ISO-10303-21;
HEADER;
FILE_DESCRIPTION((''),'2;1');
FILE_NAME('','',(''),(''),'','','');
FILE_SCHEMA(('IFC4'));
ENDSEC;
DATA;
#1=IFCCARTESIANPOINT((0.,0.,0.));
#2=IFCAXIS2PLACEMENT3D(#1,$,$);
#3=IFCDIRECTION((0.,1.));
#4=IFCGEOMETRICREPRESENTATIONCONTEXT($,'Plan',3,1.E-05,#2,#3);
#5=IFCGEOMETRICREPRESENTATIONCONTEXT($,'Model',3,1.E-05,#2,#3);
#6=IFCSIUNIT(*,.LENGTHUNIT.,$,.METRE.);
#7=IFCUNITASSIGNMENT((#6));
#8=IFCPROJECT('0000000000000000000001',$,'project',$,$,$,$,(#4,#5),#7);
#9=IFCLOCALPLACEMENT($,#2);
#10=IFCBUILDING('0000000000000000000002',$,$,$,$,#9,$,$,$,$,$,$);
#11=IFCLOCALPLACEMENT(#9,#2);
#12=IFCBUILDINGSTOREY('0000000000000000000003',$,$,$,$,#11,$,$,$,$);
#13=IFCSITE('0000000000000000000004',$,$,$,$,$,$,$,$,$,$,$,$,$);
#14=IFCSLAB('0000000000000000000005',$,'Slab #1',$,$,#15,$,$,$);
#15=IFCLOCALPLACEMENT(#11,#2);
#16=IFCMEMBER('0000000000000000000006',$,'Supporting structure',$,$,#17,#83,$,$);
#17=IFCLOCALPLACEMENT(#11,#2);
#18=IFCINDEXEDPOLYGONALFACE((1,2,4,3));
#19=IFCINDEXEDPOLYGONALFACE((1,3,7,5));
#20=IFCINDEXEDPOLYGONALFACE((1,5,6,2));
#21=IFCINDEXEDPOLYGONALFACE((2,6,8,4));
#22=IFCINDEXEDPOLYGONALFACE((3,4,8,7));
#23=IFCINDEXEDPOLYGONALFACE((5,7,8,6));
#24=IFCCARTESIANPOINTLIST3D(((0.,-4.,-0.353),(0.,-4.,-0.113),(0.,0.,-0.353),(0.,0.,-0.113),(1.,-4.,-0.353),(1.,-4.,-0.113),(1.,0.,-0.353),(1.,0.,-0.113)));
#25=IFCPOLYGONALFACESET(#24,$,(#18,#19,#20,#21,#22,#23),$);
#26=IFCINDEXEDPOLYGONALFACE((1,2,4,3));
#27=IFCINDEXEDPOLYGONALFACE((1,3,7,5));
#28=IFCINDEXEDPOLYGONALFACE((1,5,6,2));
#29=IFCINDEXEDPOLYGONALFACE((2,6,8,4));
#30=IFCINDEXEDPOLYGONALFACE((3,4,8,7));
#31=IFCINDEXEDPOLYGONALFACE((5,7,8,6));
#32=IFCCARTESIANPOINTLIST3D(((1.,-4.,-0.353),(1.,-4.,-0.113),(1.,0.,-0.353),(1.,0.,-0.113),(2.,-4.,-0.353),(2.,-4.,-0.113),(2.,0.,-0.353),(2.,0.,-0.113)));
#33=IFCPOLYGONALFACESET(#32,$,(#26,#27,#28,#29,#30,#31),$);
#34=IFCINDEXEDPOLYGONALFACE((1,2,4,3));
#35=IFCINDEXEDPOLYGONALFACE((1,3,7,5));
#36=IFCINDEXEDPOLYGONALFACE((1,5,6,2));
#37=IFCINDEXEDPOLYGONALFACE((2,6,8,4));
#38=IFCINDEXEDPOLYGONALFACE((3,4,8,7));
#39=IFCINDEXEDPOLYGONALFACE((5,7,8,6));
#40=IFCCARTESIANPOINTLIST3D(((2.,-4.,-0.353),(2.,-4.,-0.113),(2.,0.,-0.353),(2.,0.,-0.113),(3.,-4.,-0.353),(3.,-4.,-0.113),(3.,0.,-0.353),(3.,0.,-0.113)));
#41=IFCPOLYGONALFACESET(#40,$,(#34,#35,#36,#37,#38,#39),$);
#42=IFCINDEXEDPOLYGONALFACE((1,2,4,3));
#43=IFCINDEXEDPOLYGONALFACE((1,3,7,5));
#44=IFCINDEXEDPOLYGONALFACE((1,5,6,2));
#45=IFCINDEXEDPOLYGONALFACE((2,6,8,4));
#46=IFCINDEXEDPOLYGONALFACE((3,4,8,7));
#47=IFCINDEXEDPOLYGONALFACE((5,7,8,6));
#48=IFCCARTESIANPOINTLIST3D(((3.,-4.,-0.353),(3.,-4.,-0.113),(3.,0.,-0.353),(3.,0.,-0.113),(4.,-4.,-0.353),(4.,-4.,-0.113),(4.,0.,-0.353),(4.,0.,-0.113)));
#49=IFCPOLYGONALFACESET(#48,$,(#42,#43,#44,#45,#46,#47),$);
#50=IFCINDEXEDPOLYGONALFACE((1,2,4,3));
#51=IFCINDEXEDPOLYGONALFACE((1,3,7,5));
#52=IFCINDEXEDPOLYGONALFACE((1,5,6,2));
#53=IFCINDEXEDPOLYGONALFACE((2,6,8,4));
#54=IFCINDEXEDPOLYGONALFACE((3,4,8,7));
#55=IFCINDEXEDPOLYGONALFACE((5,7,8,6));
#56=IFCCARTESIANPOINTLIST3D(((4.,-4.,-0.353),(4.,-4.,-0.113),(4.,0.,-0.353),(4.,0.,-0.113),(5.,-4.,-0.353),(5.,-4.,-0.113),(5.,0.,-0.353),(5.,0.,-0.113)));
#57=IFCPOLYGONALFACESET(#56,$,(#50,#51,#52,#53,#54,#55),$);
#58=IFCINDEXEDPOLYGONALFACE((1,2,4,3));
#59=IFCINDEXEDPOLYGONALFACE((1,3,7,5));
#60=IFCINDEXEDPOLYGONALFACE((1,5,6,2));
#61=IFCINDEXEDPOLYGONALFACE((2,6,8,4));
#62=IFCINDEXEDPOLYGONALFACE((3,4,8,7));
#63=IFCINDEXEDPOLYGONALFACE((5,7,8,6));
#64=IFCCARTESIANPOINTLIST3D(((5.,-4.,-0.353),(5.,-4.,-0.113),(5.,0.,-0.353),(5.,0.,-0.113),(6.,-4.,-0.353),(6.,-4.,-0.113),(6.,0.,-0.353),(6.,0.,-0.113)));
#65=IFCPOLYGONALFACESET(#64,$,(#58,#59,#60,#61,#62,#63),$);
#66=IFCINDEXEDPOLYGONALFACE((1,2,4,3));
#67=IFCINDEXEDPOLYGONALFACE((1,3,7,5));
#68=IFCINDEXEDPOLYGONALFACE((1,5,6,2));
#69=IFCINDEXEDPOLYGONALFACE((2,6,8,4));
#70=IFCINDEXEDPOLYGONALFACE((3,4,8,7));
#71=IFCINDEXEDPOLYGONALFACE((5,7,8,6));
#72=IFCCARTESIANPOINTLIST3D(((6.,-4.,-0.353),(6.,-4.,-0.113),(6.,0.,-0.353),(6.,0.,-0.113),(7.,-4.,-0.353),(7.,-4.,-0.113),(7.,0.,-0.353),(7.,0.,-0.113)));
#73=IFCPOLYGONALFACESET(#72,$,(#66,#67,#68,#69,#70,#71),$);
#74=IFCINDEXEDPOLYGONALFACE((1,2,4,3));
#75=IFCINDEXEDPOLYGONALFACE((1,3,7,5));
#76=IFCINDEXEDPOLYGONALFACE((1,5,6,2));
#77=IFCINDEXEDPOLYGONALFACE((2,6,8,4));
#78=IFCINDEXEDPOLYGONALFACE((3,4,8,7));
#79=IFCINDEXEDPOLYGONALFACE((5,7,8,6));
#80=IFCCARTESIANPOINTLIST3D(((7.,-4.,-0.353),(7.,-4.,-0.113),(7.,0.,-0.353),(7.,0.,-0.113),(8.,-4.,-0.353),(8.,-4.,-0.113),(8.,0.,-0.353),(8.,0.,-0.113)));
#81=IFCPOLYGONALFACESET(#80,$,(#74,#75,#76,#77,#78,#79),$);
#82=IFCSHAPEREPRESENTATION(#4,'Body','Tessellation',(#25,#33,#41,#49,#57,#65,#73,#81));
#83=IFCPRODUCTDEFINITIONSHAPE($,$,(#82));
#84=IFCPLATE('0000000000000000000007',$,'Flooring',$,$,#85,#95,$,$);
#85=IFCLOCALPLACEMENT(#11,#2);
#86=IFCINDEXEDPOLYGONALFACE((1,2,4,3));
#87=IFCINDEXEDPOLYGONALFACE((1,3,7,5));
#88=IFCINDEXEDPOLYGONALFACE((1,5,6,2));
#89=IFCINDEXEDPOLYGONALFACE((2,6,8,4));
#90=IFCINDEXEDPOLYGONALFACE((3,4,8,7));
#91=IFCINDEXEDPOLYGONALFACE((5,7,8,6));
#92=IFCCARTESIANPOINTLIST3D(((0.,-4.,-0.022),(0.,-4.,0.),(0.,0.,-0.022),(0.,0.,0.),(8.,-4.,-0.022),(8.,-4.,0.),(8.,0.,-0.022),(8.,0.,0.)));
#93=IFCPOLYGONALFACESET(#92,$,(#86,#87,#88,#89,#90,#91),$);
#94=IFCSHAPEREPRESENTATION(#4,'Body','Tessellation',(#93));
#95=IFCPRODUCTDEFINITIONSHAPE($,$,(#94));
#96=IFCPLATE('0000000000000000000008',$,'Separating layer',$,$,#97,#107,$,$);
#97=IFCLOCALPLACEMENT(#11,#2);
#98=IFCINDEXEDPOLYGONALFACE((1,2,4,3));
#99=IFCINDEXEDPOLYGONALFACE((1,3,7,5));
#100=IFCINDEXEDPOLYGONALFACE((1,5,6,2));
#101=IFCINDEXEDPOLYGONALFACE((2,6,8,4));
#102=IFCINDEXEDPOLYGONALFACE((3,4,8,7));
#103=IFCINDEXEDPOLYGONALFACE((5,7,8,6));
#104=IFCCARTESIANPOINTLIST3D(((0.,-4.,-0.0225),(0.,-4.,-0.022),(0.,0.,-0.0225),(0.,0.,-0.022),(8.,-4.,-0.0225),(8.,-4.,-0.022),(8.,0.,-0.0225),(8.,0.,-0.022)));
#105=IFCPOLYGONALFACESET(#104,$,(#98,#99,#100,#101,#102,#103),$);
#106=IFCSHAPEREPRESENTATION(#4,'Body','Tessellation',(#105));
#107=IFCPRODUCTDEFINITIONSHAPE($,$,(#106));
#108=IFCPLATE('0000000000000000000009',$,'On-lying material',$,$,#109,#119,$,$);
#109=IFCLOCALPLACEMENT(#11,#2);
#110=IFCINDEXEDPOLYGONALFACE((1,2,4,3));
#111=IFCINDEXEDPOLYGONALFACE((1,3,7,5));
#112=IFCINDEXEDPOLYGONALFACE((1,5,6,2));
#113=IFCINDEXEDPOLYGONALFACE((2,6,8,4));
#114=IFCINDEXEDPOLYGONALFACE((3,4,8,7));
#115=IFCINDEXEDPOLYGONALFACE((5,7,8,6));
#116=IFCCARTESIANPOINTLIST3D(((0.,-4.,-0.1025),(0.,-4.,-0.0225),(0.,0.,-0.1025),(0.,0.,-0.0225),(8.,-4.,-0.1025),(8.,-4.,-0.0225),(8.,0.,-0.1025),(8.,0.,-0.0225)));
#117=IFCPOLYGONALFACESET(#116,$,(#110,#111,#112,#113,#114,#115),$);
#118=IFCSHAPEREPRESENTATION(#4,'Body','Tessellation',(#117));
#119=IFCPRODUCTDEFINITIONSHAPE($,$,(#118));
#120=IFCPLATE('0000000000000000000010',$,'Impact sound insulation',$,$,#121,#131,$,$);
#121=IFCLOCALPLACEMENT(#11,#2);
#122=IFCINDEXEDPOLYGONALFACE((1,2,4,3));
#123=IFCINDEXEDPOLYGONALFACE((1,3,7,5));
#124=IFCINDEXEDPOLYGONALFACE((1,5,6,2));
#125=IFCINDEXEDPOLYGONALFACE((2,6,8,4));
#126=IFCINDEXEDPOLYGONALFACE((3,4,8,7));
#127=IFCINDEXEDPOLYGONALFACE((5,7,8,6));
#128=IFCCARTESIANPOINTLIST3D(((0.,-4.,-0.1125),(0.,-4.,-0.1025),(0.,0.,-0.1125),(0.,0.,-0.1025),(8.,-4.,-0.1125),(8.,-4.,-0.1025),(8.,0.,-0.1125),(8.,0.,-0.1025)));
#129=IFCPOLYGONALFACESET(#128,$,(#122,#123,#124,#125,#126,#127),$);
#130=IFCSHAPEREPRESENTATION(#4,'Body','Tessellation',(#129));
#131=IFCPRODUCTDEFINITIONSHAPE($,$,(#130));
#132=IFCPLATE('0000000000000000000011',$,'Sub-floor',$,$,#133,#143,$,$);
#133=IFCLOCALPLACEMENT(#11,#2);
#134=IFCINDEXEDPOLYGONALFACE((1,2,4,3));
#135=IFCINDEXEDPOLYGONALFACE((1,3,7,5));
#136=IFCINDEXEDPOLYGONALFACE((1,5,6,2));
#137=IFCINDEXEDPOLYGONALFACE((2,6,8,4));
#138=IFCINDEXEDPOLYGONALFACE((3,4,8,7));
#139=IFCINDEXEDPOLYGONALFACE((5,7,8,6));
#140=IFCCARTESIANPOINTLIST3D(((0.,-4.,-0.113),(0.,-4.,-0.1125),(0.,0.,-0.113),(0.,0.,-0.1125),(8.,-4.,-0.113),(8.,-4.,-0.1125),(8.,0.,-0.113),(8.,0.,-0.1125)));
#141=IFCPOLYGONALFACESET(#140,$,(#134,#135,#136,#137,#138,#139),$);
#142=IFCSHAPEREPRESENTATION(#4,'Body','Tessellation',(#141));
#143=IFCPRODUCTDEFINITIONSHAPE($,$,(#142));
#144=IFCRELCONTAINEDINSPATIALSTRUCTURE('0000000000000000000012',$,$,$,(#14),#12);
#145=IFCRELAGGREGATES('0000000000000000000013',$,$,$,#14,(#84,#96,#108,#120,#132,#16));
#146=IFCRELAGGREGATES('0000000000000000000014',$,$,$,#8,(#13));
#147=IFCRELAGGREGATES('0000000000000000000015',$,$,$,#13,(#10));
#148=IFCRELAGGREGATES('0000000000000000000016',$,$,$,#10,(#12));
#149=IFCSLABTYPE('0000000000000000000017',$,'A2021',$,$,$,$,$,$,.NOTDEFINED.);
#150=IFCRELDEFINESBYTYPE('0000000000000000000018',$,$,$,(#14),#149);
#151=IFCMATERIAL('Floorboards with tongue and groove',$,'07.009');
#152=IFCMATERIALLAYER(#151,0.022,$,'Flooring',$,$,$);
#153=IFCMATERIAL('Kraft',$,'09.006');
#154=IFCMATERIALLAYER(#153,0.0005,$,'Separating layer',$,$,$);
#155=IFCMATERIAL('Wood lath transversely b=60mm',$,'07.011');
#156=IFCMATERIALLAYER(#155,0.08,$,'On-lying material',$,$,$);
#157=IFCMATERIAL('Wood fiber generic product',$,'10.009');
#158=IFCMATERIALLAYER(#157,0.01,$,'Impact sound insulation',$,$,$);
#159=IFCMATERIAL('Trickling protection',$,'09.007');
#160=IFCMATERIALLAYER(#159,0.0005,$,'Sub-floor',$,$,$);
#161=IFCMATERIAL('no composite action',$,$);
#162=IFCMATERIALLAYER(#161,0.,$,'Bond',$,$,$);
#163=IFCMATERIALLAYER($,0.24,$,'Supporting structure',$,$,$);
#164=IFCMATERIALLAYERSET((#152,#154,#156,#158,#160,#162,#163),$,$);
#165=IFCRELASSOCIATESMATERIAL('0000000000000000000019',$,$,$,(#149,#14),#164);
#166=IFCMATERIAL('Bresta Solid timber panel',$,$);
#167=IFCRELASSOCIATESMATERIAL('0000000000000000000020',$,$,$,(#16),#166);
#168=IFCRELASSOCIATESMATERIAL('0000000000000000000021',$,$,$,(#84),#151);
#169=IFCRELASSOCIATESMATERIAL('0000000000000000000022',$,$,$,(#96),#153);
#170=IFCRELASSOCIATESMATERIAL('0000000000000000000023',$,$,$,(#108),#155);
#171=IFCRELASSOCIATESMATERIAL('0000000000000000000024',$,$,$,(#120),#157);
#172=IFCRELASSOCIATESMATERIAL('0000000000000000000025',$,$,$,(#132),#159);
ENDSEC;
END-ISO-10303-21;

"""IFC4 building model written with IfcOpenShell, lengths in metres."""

from ifc_helpers import new_model, si_unit, direction, frame, frame_2d, origin, origin_with_axes, place, context, project, spatial, rectangle, extrude, material, layer, layer_set, type_object, element, aggregate, save


model = new_model("IFC4")

# Units and contexts
plan_context = context("Plan", 3, precision=1e-05, world=origin(), true_north=direction((0.0, 1.0)))
model_context = context("Model", 3, precision=1e-05, world=origin(), true_north=direction((0.0, 1.0)))
ifc_project = project(units=[si_unit("LENGTHUNIT", "METRE")], contexts=[plan_context, model_context])

# Site, building, storey
site = spatial("IfcSite", under=ifc_project)
building_placement = place(None, origin())
building = spatial("IfcBuilding", under=site, at=building_placement)
storey_placement = place(building_placement, origin())
storey = spatial("IfcBuildingStorey", under=building, at=storey_placement)

# Slab, member, plates
ifc_material_1 = material(Name="Floorboards with tongue and groove", Category="07.009")
ifc_layer_1 = layer(ifc_material_1, 0.022, Name="Flooring")
ifc_material_2 = material(Name="Kraft", Category="09.006")
ifc_layer_2 = layer(ifc_material_2, 0.0005, Name="Separating layer")
ifc_material_3 = material(Name="Wood lath transversely b=60mm", Category="07.011")
ifc_layer_3 = layer(ifc_material_3, 0.08, Name="On-lying material")
ifc_material_4 = material(Name="Wood fiber generic product", Category="10.009")
ifc_layer_4 = layer(ifc_material_4, 0.01, Name="Impact sound insulation")
ifc_material_5 = material(Name="Trickling protection", Category="09.007")
ifc_layer_5 = layer(ifc_material_5, 0.0005, Name="Sub-floor")
ifc_material_6 = material(Name="no composite action")
ifc_layer_6 = layer(ifc_material_6, 0.0, Name="Bond")
ifc_layer_7 = layer(None, 0.24, Name="Supporting structure")
ifc_layer_set = layer_set([ifc_layer_1, ifc_layer_2, ifc_layer_3, ifc_layer_4, ifc_layer_5, ifc_layer_6, ifc_layer_7])
slab_type = type_object("IfcSlabType", Name="A2021", PredefinedType="NOTDEFINED", material=ifc_layer_set)
slab_placement = place(None, frame((0.0, 0.0, 0.0), z_axis=(0.0, 0.0, -1.0), x_axis=(1.0, 0.0, 0.0)))
slab = element("IfcSlab", 1, at=slab_placement, inside=storey, type_object=slab_type, material=ifc_layer_set, Name="Slab #1")
ifc_material_7 = material(Name="Bresta Solid timber panel")
member_placement = place(slab_placement, origin())
member = element("IfcMember", 2, at=member_placement, material=ifc_material_7, Name="Supporting structure", context=plan_context, shape_type="SweptSolid", body=[
    extrude(rectangle(XDim=1.0, YDim=0.24, at=frame_2d((0.5, 0.12), x_axis=(1.0, 0.0))), frame((0.0, 4.0, 0.113), z_axis=(0.0, -1.0, 0.0), x_axis=(1.0, 0.0, 0.0)), (0.0, 0.0, 1.0), 4.0),
    extrude(rectangle(XDim=1.0, YDim=0.24, at=frame_2d((0.5, 0.12), x_axis=(1.0, 0.0))), frame((1.0, 4.0, 0.113), z_axis=(0.0, -1.0, 0.0), x_axis=(1.0, 0.0, 0.0)), (0.0, 0.0, 1.0), 4.0),
    extrude(rectangle(XDim=1.0, YDim=0.24, at=frame_2d((0.5, 0.12), x_axis=(1.0, 0.0))), frame((2.0, 4.0, 0.113), z_axis=(0.0, -1.0, 0.0), x_axis=(1.0, 0.0, 0.0)), (0.0, 0.0, 1.0), 4.0),
    extrude(rectangle(XDim=1.0, YDim=0.24, at=frame_2d((0.5, 0.12), x_axis=(1.0, 0.0))), frame((3.0, 4.0, 0.113), z_axis=(0.0, -1.0, 0.0), x_axis=(1.0, 0.0, 0.0)), (0.0, 0.0, 1.0), 4.0),
    extrude(rectangle(XDim=1.0, YDim=0.24, at=frame_2d((0.5, 0.12), x_axis=(1.0, 0.0))), frame((4.0, 4.0, 0.113), z_axis=(0.0, -1.0, 0.0), x_axis=(1.0, 0.0, 0.0)), (0.0, 0.0, 1.0), 4.0),
    extrude(rectangle(XDim=1.0, YDim=0.24, at=frame_2d((0.5, 0.12), x_axis=(1.0, 0.0))), frame((5.0, 4.0, 0.113), z_axis=(0.0, -1.0, 0.0), x_axis=(1.0, 0.0, 0.0)), (0.0, 0.0, 1.0), 4.0),
    extrude(rectangle(XDim=1.0, YDim=0.24, at=frame_2d((0.5, 0.12), x_axis=(1.0, 0.0))), frame((6.0, 4.0, 0.113), z_axis=(0.0, -1.0, 0.0), x_axis=(1.0, 0.0, 0.0)), (0.0, 0.0, 1.0), 4.0),
    extrude(rectangle(XDim=1.0, YDim=0.24, at=frame_2d((0.5, 0.12), x_axis=(1.0, 0.0))), frame((7.0, 4.0, 0.113), z_axis=(0.0, -1.0, 0.0), x_axis=(1.0, 0.0, 0.0)), (0.0, 0.0, 1.0), 4.0),
])
plate_1_placement = place(slab_placement, origin())
plate_1 = element("IfcPlate", 3, at=plate_1_placement, material=ifc_material_1, Name="Flooring", context=plan_context, shape_type="SweptSolid", body=[
    extrude(rectangle(XDim=8.0, YDim=4.0, at=frame_2d((4.0, 2.0), x_axis=(1.0, 0.0))), origin_with_axes(), (0.0, 0.0, 1.0), 0.022),
])
plate_2_placement = place(slab_placement, origin())
plate_2 = element("IfcPlate", 4, at=plate_2_placement, material=ifc_material_2, Name="Separating layer", context=plan_context, shape_type="SweptSolid", body=[
    extrude(rectangle(XDim=8.0, YDim=4.0, at=frame_2d((4.0, 2.0), x_axis=(1.0, 0.0))), frame((0.0, 0.0, 0.022), z_axis=(0.0, 0.0, 1.0), x_axis=(1.0, 0.0, 0.0)), (0.0, 0.0, 1.0), 0.0005),
])
plate_3_placement = place(slab_placement, origin())
plate_3 = element("IfcPlate", 5, at=plate_3_placement, material=ifc_material_3, Name="On-lying material", context=plan_context, shape_type="SweptSolid", body=[
    extrude(rectangle(XDim=8.0, YDim=4.0, at=frame_2d((4.0, 2.0), x_axis=(1.0, 0.0))), frame((0.0, 0.0, 0.0225), z_axis=(0.0, 0.0, 1.0), x_axis=(1.0, 0.0, 0.0)), (0.0, 0.0, 1.0), 0.08),
])
plate_4_placement = place(slab_placement, origin())
plate_4 = element("IfcPlate", 6, at=plate_4_placement, material=ifc_material_4, Name="Impact sound insulation", context=plan_context, shape_type="SweptSolid", body=[
    extrude(rectangle(XDim=8.0, YDim=4.0, at=frame_2d((4.0, 2.0), x_axis=(1.0, 0.0))), frame((0.0, 0.0, 0.1025), z_axis=(0.0, 0.0, 1.0), x_axis=(1.0, 0.0, 0.0)), (0.0, 0.0, 1.0), 0.01),
])
plate_5_placement = place(slab_placement, origin())
plate_5 = element("IfcPlate", 7, at=plate_5_placement, material=ifc_material_5, Name="Sub-floor", context=plan_context, shape_type="SweptSolid", body=[
    extrude(rectangle(XDim=8.0, YDim=4.0, at=frame_2d((4.0, 2.0), x_axis=(1.0, 0.0))), frame((0.0, 0.0, 0.1125), z_axis=(0.0, 0.0, 1.0), x_axis=(1.0, 0.0, 0.0)), (0.0, 0.0, 1.0), 0.0005),
])
aggregate(slab, [plate_1, plate_2, plate_3, plate_4, plate_5, member])

save(model, "model.ifc")
